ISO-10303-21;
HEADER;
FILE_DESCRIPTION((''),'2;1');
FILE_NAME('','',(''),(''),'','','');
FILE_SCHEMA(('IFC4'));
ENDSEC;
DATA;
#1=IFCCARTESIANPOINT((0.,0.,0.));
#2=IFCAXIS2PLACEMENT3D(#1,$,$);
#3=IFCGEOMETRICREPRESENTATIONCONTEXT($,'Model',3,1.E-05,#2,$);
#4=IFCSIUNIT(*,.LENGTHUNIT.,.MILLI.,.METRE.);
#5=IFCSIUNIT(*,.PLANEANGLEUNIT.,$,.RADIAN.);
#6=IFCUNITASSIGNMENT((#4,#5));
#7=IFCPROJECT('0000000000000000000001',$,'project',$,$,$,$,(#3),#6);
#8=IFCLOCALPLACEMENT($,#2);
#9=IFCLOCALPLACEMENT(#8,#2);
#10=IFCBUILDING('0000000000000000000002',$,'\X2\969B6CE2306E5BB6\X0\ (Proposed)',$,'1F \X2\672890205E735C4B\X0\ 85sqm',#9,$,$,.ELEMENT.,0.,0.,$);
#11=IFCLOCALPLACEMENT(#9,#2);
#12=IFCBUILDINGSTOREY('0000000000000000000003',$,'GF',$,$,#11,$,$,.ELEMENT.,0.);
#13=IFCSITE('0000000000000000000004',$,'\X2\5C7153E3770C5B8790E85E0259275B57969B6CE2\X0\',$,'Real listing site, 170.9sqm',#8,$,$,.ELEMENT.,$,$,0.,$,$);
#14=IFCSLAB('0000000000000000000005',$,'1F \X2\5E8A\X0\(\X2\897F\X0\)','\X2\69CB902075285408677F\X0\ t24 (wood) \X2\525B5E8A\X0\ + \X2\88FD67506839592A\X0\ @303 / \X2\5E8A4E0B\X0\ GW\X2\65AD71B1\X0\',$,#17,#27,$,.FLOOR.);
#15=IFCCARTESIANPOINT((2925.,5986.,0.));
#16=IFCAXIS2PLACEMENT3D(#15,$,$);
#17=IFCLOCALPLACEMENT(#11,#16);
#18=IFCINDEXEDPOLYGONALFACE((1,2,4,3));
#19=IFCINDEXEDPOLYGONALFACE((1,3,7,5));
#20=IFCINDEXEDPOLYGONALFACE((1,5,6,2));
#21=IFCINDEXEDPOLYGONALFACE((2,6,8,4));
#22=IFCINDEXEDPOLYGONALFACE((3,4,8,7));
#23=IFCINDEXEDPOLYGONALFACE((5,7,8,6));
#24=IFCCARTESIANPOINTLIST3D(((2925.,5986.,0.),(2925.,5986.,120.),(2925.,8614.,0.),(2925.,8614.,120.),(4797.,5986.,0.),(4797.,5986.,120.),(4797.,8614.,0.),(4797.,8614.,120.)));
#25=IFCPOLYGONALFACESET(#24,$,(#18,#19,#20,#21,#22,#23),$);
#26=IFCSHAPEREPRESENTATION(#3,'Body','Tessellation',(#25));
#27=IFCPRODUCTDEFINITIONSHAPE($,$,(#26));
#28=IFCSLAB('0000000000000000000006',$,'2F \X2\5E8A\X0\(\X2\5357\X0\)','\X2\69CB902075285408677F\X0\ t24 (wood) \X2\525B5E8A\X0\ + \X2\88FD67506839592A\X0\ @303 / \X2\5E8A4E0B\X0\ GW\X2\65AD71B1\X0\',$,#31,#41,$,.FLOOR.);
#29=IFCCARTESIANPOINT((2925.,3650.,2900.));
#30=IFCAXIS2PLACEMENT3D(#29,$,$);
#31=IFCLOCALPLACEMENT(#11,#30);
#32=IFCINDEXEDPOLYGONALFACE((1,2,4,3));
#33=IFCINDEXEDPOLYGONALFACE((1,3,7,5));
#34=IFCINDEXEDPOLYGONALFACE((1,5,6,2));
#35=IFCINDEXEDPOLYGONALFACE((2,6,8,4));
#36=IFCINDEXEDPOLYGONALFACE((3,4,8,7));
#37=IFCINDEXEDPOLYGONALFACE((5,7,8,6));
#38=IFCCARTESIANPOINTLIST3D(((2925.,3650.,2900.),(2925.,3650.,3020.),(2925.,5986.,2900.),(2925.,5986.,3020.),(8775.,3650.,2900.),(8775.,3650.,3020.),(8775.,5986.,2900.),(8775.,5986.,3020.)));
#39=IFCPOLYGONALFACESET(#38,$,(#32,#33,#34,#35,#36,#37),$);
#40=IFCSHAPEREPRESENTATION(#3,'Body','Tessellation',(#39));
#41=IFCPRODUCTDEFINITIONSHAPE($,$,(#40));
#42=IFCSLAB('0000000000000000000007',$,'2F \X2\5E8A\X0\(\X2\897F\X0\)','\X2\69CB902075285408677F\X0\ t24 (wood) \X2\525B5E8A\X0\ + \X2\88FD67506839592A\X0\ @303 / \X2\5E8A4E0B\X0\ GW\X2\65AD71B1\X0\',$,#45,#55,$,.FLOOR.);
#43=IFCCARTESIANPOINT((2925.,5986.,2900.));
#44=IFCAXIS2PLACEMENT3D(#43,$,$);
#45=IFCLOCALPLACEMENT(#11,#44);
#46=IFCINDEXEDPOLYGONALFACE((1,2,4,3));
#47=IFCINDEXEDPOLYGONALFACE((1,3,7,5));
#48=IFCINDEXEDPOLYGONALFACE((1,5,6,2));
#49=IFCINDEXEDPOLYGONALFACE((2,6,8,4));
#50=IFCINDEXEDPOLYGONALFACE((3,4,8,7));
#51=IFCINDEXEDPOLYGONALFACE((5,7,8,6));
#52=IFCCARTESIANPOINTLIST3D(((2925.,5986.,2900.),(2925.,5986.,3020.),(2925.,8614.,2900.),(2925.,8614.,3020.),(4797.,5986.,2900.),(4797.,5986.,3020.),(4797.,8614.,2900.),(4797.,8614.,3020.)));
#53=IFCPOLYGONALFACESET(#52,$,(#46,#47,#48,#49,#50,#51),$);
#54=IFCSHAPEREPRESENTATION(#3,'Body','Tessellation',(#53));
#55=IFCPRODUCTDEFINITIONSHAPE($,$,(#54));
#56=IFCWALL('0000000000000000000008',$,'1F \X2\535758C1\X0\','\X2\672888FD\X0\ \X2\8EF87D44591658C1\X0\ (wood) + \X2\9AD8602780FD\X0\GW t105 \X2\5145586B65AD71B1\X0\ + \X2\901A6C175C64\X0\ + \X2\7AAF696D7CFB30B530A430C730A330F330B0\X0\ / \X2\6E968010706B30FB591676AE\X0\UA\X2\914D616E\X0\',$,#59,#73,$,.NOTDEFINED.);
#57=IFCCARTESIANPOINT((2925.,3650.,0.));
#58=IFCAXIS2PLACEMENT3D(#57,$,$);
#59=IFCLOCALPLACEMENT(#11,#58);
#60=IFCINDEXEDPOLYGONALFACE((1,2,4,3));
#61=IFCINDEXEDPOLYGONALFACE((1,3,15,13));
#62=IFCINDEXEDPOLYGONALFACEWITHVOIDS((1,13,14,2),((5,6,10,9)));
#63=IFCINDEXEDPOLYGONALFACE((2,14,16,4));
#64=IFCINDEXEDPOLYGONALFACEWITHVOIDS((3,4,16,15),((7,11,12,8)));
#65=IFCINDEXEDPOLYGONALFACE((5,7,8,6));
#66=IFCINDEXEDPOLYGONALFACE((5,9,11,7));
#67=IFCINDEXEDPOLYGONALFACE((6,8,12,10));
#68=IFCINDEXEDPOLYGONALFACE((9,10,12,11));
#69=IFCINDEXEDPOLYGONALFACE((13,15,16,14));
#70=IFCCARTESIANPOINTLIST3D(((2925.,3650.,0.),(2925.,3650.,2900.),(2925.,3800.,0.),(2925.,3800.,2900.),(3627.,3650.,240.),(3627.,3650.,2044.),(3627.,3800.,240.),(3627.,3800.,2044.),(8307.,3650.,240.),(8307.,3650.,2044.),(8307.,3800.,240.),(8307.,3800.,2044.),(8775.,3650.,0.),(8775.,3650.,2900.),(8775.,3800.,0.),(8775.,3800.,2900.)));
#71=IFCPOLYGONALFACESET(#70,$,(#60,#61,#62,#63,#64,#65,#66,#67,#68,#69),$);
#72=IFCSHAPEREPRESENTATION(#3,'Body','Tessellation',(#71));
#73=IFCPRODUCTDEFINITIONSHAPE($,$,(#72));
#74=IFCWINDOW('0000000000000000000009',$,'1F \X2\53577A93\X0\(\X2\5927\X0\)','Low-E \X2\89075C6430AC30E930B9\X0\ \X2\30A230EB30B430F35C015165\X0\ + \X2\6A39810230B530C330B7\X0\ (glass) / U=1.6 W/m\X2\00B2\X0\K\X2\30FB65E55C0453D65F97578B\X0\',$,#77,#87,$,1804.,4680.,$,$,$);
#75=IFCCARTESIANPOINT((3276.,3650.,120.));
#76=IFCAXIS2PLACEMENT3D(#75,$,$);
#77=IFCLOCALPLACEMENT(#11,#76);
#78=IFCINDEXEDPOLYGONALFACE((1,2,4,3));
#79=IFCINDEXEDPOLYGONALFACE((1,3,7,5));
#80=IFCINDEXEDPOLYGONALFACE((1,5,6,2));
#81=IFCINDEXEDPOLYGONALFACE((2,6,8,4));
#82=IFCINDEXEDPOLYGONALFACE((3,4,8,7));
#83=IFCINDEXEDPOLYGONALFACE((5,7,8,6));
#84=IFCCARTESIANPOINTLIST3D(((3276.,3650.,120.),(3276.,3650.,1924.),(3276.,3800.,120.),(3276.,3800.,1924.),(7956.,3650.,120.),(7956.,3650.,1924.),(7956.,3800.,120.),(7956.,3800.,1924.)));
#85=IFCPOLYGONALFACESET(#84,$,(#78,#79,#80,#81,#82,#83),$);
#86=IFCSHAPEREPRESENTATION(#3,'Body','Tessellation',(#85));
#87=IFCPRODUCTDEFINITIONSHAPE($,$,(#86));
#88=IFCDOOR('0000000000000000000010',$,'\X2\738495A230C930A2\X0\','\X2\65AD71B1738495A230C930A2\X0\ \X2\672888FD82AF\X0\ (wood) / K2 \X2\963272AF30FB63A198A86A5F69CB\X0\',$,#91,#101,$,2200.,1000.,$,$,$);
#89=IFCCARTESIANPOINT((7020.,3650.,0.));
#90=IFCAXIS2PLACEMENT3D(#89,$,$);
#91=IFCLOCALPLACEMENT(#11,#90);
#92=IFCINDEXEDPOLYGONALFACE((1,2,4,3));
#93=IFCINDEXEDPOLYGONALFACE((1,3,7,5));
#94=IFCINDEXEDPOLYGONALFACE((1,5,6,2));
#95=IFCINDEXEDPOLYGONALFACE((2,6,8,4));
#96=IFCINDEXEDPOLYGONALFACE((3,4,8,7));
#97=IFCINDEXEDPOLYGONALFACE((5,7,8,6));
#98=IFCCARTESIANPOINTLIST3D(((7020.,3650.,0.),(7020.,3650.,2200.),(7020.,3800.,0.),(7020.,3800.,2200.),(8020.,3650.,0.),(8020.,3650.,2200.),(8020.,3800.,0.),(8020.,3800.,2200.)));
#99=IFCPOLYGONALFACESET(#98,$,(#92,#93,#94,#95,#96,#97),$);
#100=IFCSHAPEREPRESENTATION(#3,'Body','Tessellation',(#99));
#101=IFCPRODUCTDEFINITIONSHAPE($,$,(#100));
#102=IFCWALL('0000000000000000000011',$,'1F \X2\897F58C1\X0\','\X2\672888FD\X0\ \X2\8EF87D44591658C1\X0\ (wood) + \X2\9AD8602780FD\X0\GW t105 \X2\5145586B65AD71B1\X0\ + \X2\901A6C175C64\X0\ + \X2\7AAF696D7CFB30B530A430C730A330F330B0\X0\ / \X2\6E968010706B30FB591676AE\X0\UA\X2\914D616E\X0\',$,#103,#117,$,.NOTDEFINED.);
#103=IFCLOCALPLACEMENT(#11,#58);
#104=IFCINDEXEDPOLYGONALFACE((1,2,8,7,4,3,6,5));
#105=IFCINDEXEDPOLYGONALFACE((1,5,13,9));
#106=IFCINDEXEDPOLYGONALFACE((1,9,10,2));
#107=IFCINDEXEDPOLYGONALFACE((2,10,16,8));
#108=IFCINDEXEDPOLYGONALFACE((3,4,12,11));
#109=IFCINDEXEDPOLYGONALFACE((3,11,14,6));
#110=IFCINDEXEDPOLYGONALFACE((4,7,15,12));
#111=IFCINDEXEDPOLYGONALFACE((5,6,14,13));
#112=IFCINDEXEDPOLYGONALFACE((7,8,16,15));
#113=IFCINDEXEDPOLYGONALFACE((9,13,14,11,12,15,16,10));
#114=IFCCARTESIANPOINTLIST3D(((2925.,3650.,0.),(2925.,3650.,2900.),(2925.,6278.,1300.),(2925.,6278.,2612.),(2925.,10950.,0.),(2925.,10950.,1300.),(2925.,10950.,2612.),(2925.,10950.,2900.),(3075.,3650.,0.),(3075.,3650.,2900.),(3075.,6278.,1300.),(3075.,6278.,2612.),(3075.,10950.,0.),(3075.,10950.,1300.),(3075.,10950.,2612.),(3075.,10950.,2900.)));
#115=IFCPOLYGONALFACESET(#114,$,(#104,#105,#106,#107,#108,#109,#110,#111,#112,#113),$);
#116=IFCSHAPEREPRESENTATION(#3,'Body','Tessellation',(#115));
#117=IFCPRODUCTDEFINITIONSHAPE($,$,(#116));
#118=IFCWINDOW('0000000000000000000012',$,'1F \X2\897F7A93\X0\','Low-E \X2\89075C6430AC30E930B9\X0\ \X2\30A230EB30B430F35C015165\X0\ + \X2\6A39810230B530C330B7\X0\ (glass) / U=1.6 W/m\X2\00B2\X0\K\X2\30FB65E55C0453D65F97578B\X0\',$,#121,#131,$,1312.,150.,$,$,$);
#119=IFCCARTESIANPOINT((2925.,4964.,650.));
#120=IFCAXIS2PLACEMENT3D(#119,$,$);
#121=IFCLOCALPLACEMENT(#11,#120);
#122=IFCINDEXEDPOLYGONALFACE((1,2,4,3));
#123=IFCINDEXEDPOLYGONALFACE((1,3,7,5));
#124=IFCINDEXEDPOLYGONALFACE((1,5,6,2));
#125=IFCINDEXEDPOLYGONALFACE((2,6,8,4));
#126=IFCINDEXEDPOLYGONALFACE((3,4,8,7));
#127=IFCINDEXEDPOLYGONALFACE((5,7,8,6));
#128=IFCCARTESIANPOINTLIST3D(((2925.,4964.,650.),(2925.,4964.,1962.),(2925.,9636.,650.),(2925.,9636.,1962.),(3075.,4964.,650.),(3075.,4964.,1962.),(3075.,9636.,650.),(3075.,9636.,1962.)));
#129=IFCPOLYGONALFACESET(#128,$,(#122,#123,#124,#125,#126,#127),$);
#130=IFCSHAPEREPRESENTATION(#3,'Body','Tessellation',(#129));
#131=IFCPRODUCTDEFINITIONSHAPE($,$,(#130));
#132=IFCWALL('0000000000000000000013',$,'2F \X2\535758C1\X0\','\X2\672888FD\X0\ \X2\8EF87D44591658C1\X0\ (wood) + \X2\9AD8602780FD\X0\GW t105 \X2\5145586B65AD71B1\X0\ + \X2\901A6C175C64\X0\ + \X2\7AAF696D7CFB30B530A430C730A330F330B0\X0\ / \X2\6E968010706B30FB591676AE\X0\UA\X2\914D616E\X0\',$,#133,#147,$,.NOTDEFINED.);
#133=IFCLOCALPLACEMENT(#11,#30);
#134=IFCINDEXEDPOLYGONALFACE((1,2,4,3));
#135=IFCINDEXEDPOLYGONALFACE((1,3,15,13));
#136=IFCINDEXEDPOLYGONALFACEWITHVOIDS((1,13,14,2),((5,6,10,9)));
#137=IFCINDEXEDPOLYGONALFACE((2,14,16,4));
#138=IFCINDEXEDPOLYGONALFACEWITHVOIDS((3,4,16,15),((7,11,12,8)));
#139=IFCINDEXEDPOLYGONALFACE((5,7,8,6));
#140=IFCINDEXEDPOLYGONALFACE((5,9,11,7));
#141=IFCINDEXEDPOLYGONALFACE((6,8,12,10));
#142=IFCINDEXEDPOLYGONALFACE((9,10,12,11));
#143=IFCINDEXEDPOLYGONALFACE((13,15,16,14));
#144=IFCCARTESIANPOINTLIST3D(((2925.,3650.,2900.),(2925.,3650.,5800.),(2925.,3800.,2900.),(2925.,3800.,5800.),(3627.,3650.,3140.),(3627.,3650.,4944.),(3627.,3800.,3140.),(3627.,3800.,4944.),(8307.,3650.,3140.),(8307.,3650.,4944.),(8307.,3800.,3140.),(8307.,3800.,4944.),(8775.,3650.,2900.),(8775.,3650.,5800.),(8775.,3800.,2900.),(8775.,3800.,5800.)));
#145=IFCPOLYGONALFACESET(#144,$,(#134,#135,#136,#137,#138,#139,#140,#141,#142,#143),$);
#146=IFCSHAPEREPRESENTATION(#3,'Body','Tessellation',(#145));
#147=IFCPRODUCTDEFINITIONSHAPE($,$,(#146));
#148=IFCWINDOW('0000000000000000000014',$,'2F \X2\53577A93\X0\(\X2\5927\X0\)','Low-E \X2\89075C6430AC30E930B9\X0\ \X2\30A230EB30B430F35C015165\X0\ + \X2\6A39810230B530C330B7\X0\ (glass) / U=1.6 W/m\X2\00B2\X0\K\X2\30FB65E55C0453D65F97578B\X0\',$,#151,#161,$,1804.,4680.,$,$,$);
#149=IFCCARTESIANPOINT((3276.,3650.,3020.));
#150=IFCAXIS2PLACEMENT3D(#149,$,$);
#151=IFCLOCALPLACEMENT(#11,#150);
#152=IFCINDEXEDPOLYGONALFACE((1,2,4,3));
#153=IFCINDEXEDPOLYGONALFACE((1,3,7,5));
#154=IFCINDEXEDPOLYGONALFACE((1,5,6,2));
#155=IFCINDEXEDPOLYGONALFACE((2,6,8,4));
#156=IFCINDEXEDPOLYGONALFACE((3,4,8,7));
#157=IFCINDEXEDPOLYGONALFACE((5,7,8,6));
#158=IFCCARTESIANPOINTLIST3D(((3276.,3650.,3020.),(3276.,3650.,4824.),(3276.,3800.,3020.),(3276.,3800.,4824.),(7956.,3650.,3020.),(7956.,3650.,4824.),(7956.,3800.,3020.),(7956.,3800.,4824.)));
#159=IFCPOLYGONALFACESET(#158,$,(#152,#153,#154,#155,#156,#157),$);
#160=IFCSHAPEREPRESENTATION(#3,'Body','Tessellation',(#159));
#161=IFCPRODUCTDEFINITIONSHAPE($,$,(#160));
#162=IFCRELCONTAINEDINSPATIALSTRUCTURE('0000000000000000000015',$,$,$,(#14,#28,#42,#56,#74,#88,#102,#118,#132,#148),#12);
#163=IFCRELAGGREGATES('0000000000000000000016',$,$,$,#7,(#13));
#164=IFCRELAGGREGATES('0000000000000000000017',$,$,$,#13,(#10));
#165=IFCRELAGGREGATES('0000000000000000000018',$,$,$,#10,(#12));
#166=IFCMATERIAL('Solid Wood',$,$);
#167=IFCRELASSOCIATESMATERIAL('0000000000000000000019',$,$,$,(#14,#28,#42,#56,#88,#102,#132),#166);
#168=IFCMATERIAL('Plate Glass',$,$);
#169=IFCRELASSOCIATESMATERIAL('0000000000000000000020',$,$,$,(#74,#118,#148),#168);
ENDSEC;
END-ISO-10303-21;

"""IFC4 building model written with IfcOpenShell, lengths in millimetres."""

from ifc_helpers import new_model, si_unit, frame, frame_2d, origin, place, context, project, spatial, rectangle, extrude, material, element, fill, save


model = new_model("IFC4")

# Units and contexts
model_context = context("Model", 3, precision=1e-05, world=origin())
ifc_project = project(units=[si_unit("LENGTHUNIT", "METRE", prefix="MILLI"), si_unit("PLANEANGLEUNIT", "RADIAN")], contexts=[model_context])

# Site, building, storey
site_placement = place(None, origin())
site = spatial("IfcSite", under=ifc_project, at=site_placement, Name="山口県宇部市大字際波", ObjectType="Real listing site, 170.9sqm", CompositionType="ELEMENT", RefElevation=0.0)
building_placement = place(site_placement, origin())
building = spatial("IfcBuilding", under=site, at=building_placement, Name="際波の家 (Proposed)", ObjectType="1F 木造平屋 85sqm", CompositionType="ELEMENT", ElevationOfRefHeight=0.0, ElevationOfTerrain=0.0)
storey_placement = place(building_placement, origin())
storey = spatial("IfcBuildingStorey", under=building, at=storey_placement, Name="GF", CompositionType="ELEMENT", Elevation=0.0)

# Slabs
ifc_material_1 = material(Name="Solid Wood")
slab_1_placement = place(storey_placement, frame((2925.0, 5986.0, 0.0)))
element("IfcSlab", 1, at=slab_1_placement, inside=storey, material=ifc_material_1, Name="1F 床(西)", Description="構造用合板 t24 (wood) 剛床 + 製材根太 @303 / 床下 GW断熱", PredefinedType="FLOOR", context=model_context, shape_type="SweptSolid", body=[
    extrude(rectangle(XDim=1872.0, YDim=2628.0, at=frame_2d((936.0, 1314.0))), frame((2925.0, 5986.0, 0.0)), (0.0, 0.0, 1.0), 120.0),
])
slab_2_placement = place(storey_placement, frame((2925.0, 3650.0, 2900.0)))
element("IfcSlab", 2, at=slab_2_placement, inside=storey, material=ifc_material_1, Name="2F 床(南)", Description="構造用合板 t24 (wood) 剛床 + 製材根太 @303 / 床下 GW断熱", PredefinedType="FLOOR", context=model_context, shape_type="SweptSolid", body=[
    extrude(rectangle(XDim=5850.0, YDim=2336.0, at=frame_2d((2925.0, 1168.0))), frame((2925.0, 3650.0, 2900.0)), (0.0, 0.0, 1.0), 120.0),
])
slab_3_placement = place(storey_placement, frame((2925.0, 5986.0, 2900.0)))
element("IfcSlab", 3, at=slab_3_placement, inside=storey, material=ifc_material_1, Name="2F 床(西)", Description="構造用合板 t24 (wood) 剛床 + 製材根太 @303 / 床下 GW断熱", PredefinedType="FLOOR", context=model_context, shape_type="SweptSolid", body=[
    extrude(rectangle(XDim=1872.0, YDim=2628.0, at=frame_2d((936.0, 1314.0))), frame((2925.0, 5986.0, 2900.0)), (0.0, 0.0, 1.0), 120.0),
])

# Wall, openings, window, door
wall_1_placement = place(storey_placement, frame((2925.0, 3650.0, 0.0)))
wall_1 = element("IfcWall", 4, at=wall_1_placement, inside=storey, material=ifc_material_1, Name="1F 南壁", Description="木製 軸組外壁 (wood) + 高性能GW t105 充填断熱 + 通気層 + 窯業系サイディング / 準耐火・外皮UA配慮", PredefinedType="NOTDEFINED", context=model_context, shape_type="SweptSolid", body=[
    extrude(rectangle(XDim=5850.0, YDim=150.0, at=frame_2d((2925.0, 75.0))), frame((2925.0, 3650.0, 0.0)), (0.0, 0.0, 1.0), 2900.0),
])
opening_1_placement = place(storey_placement, frame((3276.0, 3650.0, 120.0)))
opening_1 = element("IfcOpeningElement", 5, at=opening_1_placement, cuts=wall_1, PredefinedType="NOTDEFINED", context=model_context, shape_type="SweptSolid", body=[
    extrude(rectangle(XDim=4680.0, YDim=150.0, at=frame_2d((2340.0, 75.0))), frame((3276.0, 3650.0, 120.0)), (0.0, 0.0, 1.0), 1804.0),
])
opening_2_placement = place(storey_placement, frame((7020.0, 3650.0, 0.0)))
opening_2 = element("IfcOpeningElement", 6, at=opening_2_placement, cuts=wall_1, PredefinedType="NOTDEFINED", context=model_context, shape_type="SweptSolid", body=[
    extrude(rectangle(XDim=1000.0, YDim=150.0, at=frame_2d((500.0, 75.0))), frame((7020.0, 3650.0, 0.0)), (0.0, 0.0, 1.0), 2200.0),
])
ifc_material_2 = material(Name="Plate Glass")
window_1_placement = place(storey_placement, frame((3276.0, 3650.0, 120.0)))
window_1 = element("IfcWindow", 7, at=window_1_placement, inside=storey, material=ifc_material_2, Name="1F 南窓(大)", Description="Low-E 複層ガラス アルゴン封入 + 樹脂サッシ (glass) / U=1.6 W/m²K・日射取得型", OverallHeight=1804.0, OverallWidth=4680.0, context=model_context, shape_type="SweptSolid", body=[
    extrude(rectangle(XDim=4680.0, YDim=150.0, at=frame_2d((2340.0, 75.0))), frame((3276.0, 3650.0, 120.0)), (0.0, 0.0, 1.0), 1804.0),
])
fill(opening_1, window_1)
door_placement = place(storey_placement, frame((7020.0, 3650.0, 0.0)))
door = element("IfcDoor", 8, at=door_placement, inside=storey, material=ifc_material_1, Name="玄関ドア", Description="断熱玄関ドア 木製芯 (wood) / K2 防犯・採風機構", OverallHeight=2200.0, OverallWidth=1000.0, context=model_context, shape_type="SweptSolid", body=[
    extrude(rectangle(XDim=1000.0, YDim=150.0, at=frame_2d((500.0, 75.0))), frame((7020.0, 3650.0, 0.0)), (0.0, 0.0, 1.0), 2200.0),
])
fill(opening_2, door)

# Walls, openings, windows
wall_2_placement = place(storey_placement, frame((2925.0, 3650.0, 0.0)))
wall_2 = element("IfcWall", 9, at=wall_2_placement, inside=storey, material=ifc_material_1, Name="1F 西壁", Description="木製 軸組外壁 (wood) + 高性能GW t105 充填断熱 + 通気層 + 窯業系サイディング / 準耐火・外皮UA配慮", PredefinedType="NOTDEFINED", context=model_context, shape_type="SweptSolid", body=[
    extrude(rectangle(XDim=150.0, YDim=7300.0, at=frame_2d((75.0, 3650.0))), frame((2925.0, 3650.0, 0.0)), (0.0, 0.0, 1.0), 2900.0),
])
opening_3_placement = place(storey_placement, frame((2925.0, 4964.0, 650.0)))
opening_3 = element("IfcOpeningElement", 10, at=opening_3_placement, cuts=wall_2, PredefinedType="NOTDEFINED", context=model_context, shape_type="SweptSolid", body=[
    extrude(rectangle(XDim=150.0, YDim=4672.0, at=frame_2d((75.0, 2336.0))), frame((2925.0, 4964.0, 650.0)), (0.0, 0.0, 1.0), 1312.0),
])
window_2_placement = place(storey_placement, frame((2925.0, 4964.0, 650.0)))
window_2 = element("IfcWindow", 11, at=window_2_placement, inside=storey, material=ifc_material_2, Name="1F 西窓", Description="Low-E 複層ガラス アルゴン封入 + 樹脂サッシ (glass) / U=1.6 W/m²K・日射取得型", OverallHeight=1312.0, OverallWidth=150.0, context=model_context, shape_type="SweptSolid", body=[
    extrude(rectangle(XDim=150.0, YDim=4672.0, at=frame_2d((75.0, 2336.0))), frame((2925.0, 4964.0, 650.0)), (0.0, 0.0, 1.0), 1312.0),
])
fill(opening_3, window_2)
wall_3_placement = place(storey_placement, frame((2925.0, 3650.0, 2900.0)))
wall_3 = element("IfcWall", 12, at=wall_3_placement, inside=storey, material=ifc_material_1, Name="2F 南壁", Description="木製 軸組外壁 (wood) + 高性能GW t105 充填断熱 + 通気層 + 窯業系サイディング / 準耐火・外皮UA配慮", PredefinedType="NOTDEFINED", context=model_context, shape_type="SweptSolid", body=[
    extrude(rectangle(XDim=5850.0, YDim=150.0, at=frame_2d((2925.0, 75.0))), frame((2925.0, 3650.0, 2900.0)), (0.0, 0.0, 1.0), 2900.0),
])
opening_4_placement = place(storey_placement, frame((3276.0, 3650.0, 3020.0)))
opening_4 = element("IfcOpeningElement", 13, at=opening_4_placement, cuts=wall_3, PredefinedType="NOTDEFINED", context=model_context, shape_type="SweptSolid", body=[
    extrude(rectangle(XDim=4680.0, YDim=150.0, at=frame_2d((2340.0, 75.0))), frame((3276.0, 3650.0, 3020.0)), (0.0, 0.0, 1.0), 1804.0),
])
window_3_placement = place(storey_placement, frame((3276.0, 3650.0, 3020.0)))
window_3 = element("IfcWindow", 14, at=window_3_placement, inside=storey, material=ifc_material_2, Name="2F 南窓(大)", Description="Low-E 複層ガラス アルゴン封入 + 樹脂サッシ (glass) / U=1.6 W/m²K・日射取得型", OverallHeight=1804.0, OverallWidth=4680.0, context=model_context, shape_type="SweptSolid", body=[
    extrude(rectangle(XDim=4680.0, YDim=150.0, at=frame_2d((2340.0, 75.0))), frame((3276.0, 3650.0, 3020.0)), (0.0, 0.0, 1.0), 1804.0),
])
fill(opening_4, window_3)

save(model, "model.ifc")
